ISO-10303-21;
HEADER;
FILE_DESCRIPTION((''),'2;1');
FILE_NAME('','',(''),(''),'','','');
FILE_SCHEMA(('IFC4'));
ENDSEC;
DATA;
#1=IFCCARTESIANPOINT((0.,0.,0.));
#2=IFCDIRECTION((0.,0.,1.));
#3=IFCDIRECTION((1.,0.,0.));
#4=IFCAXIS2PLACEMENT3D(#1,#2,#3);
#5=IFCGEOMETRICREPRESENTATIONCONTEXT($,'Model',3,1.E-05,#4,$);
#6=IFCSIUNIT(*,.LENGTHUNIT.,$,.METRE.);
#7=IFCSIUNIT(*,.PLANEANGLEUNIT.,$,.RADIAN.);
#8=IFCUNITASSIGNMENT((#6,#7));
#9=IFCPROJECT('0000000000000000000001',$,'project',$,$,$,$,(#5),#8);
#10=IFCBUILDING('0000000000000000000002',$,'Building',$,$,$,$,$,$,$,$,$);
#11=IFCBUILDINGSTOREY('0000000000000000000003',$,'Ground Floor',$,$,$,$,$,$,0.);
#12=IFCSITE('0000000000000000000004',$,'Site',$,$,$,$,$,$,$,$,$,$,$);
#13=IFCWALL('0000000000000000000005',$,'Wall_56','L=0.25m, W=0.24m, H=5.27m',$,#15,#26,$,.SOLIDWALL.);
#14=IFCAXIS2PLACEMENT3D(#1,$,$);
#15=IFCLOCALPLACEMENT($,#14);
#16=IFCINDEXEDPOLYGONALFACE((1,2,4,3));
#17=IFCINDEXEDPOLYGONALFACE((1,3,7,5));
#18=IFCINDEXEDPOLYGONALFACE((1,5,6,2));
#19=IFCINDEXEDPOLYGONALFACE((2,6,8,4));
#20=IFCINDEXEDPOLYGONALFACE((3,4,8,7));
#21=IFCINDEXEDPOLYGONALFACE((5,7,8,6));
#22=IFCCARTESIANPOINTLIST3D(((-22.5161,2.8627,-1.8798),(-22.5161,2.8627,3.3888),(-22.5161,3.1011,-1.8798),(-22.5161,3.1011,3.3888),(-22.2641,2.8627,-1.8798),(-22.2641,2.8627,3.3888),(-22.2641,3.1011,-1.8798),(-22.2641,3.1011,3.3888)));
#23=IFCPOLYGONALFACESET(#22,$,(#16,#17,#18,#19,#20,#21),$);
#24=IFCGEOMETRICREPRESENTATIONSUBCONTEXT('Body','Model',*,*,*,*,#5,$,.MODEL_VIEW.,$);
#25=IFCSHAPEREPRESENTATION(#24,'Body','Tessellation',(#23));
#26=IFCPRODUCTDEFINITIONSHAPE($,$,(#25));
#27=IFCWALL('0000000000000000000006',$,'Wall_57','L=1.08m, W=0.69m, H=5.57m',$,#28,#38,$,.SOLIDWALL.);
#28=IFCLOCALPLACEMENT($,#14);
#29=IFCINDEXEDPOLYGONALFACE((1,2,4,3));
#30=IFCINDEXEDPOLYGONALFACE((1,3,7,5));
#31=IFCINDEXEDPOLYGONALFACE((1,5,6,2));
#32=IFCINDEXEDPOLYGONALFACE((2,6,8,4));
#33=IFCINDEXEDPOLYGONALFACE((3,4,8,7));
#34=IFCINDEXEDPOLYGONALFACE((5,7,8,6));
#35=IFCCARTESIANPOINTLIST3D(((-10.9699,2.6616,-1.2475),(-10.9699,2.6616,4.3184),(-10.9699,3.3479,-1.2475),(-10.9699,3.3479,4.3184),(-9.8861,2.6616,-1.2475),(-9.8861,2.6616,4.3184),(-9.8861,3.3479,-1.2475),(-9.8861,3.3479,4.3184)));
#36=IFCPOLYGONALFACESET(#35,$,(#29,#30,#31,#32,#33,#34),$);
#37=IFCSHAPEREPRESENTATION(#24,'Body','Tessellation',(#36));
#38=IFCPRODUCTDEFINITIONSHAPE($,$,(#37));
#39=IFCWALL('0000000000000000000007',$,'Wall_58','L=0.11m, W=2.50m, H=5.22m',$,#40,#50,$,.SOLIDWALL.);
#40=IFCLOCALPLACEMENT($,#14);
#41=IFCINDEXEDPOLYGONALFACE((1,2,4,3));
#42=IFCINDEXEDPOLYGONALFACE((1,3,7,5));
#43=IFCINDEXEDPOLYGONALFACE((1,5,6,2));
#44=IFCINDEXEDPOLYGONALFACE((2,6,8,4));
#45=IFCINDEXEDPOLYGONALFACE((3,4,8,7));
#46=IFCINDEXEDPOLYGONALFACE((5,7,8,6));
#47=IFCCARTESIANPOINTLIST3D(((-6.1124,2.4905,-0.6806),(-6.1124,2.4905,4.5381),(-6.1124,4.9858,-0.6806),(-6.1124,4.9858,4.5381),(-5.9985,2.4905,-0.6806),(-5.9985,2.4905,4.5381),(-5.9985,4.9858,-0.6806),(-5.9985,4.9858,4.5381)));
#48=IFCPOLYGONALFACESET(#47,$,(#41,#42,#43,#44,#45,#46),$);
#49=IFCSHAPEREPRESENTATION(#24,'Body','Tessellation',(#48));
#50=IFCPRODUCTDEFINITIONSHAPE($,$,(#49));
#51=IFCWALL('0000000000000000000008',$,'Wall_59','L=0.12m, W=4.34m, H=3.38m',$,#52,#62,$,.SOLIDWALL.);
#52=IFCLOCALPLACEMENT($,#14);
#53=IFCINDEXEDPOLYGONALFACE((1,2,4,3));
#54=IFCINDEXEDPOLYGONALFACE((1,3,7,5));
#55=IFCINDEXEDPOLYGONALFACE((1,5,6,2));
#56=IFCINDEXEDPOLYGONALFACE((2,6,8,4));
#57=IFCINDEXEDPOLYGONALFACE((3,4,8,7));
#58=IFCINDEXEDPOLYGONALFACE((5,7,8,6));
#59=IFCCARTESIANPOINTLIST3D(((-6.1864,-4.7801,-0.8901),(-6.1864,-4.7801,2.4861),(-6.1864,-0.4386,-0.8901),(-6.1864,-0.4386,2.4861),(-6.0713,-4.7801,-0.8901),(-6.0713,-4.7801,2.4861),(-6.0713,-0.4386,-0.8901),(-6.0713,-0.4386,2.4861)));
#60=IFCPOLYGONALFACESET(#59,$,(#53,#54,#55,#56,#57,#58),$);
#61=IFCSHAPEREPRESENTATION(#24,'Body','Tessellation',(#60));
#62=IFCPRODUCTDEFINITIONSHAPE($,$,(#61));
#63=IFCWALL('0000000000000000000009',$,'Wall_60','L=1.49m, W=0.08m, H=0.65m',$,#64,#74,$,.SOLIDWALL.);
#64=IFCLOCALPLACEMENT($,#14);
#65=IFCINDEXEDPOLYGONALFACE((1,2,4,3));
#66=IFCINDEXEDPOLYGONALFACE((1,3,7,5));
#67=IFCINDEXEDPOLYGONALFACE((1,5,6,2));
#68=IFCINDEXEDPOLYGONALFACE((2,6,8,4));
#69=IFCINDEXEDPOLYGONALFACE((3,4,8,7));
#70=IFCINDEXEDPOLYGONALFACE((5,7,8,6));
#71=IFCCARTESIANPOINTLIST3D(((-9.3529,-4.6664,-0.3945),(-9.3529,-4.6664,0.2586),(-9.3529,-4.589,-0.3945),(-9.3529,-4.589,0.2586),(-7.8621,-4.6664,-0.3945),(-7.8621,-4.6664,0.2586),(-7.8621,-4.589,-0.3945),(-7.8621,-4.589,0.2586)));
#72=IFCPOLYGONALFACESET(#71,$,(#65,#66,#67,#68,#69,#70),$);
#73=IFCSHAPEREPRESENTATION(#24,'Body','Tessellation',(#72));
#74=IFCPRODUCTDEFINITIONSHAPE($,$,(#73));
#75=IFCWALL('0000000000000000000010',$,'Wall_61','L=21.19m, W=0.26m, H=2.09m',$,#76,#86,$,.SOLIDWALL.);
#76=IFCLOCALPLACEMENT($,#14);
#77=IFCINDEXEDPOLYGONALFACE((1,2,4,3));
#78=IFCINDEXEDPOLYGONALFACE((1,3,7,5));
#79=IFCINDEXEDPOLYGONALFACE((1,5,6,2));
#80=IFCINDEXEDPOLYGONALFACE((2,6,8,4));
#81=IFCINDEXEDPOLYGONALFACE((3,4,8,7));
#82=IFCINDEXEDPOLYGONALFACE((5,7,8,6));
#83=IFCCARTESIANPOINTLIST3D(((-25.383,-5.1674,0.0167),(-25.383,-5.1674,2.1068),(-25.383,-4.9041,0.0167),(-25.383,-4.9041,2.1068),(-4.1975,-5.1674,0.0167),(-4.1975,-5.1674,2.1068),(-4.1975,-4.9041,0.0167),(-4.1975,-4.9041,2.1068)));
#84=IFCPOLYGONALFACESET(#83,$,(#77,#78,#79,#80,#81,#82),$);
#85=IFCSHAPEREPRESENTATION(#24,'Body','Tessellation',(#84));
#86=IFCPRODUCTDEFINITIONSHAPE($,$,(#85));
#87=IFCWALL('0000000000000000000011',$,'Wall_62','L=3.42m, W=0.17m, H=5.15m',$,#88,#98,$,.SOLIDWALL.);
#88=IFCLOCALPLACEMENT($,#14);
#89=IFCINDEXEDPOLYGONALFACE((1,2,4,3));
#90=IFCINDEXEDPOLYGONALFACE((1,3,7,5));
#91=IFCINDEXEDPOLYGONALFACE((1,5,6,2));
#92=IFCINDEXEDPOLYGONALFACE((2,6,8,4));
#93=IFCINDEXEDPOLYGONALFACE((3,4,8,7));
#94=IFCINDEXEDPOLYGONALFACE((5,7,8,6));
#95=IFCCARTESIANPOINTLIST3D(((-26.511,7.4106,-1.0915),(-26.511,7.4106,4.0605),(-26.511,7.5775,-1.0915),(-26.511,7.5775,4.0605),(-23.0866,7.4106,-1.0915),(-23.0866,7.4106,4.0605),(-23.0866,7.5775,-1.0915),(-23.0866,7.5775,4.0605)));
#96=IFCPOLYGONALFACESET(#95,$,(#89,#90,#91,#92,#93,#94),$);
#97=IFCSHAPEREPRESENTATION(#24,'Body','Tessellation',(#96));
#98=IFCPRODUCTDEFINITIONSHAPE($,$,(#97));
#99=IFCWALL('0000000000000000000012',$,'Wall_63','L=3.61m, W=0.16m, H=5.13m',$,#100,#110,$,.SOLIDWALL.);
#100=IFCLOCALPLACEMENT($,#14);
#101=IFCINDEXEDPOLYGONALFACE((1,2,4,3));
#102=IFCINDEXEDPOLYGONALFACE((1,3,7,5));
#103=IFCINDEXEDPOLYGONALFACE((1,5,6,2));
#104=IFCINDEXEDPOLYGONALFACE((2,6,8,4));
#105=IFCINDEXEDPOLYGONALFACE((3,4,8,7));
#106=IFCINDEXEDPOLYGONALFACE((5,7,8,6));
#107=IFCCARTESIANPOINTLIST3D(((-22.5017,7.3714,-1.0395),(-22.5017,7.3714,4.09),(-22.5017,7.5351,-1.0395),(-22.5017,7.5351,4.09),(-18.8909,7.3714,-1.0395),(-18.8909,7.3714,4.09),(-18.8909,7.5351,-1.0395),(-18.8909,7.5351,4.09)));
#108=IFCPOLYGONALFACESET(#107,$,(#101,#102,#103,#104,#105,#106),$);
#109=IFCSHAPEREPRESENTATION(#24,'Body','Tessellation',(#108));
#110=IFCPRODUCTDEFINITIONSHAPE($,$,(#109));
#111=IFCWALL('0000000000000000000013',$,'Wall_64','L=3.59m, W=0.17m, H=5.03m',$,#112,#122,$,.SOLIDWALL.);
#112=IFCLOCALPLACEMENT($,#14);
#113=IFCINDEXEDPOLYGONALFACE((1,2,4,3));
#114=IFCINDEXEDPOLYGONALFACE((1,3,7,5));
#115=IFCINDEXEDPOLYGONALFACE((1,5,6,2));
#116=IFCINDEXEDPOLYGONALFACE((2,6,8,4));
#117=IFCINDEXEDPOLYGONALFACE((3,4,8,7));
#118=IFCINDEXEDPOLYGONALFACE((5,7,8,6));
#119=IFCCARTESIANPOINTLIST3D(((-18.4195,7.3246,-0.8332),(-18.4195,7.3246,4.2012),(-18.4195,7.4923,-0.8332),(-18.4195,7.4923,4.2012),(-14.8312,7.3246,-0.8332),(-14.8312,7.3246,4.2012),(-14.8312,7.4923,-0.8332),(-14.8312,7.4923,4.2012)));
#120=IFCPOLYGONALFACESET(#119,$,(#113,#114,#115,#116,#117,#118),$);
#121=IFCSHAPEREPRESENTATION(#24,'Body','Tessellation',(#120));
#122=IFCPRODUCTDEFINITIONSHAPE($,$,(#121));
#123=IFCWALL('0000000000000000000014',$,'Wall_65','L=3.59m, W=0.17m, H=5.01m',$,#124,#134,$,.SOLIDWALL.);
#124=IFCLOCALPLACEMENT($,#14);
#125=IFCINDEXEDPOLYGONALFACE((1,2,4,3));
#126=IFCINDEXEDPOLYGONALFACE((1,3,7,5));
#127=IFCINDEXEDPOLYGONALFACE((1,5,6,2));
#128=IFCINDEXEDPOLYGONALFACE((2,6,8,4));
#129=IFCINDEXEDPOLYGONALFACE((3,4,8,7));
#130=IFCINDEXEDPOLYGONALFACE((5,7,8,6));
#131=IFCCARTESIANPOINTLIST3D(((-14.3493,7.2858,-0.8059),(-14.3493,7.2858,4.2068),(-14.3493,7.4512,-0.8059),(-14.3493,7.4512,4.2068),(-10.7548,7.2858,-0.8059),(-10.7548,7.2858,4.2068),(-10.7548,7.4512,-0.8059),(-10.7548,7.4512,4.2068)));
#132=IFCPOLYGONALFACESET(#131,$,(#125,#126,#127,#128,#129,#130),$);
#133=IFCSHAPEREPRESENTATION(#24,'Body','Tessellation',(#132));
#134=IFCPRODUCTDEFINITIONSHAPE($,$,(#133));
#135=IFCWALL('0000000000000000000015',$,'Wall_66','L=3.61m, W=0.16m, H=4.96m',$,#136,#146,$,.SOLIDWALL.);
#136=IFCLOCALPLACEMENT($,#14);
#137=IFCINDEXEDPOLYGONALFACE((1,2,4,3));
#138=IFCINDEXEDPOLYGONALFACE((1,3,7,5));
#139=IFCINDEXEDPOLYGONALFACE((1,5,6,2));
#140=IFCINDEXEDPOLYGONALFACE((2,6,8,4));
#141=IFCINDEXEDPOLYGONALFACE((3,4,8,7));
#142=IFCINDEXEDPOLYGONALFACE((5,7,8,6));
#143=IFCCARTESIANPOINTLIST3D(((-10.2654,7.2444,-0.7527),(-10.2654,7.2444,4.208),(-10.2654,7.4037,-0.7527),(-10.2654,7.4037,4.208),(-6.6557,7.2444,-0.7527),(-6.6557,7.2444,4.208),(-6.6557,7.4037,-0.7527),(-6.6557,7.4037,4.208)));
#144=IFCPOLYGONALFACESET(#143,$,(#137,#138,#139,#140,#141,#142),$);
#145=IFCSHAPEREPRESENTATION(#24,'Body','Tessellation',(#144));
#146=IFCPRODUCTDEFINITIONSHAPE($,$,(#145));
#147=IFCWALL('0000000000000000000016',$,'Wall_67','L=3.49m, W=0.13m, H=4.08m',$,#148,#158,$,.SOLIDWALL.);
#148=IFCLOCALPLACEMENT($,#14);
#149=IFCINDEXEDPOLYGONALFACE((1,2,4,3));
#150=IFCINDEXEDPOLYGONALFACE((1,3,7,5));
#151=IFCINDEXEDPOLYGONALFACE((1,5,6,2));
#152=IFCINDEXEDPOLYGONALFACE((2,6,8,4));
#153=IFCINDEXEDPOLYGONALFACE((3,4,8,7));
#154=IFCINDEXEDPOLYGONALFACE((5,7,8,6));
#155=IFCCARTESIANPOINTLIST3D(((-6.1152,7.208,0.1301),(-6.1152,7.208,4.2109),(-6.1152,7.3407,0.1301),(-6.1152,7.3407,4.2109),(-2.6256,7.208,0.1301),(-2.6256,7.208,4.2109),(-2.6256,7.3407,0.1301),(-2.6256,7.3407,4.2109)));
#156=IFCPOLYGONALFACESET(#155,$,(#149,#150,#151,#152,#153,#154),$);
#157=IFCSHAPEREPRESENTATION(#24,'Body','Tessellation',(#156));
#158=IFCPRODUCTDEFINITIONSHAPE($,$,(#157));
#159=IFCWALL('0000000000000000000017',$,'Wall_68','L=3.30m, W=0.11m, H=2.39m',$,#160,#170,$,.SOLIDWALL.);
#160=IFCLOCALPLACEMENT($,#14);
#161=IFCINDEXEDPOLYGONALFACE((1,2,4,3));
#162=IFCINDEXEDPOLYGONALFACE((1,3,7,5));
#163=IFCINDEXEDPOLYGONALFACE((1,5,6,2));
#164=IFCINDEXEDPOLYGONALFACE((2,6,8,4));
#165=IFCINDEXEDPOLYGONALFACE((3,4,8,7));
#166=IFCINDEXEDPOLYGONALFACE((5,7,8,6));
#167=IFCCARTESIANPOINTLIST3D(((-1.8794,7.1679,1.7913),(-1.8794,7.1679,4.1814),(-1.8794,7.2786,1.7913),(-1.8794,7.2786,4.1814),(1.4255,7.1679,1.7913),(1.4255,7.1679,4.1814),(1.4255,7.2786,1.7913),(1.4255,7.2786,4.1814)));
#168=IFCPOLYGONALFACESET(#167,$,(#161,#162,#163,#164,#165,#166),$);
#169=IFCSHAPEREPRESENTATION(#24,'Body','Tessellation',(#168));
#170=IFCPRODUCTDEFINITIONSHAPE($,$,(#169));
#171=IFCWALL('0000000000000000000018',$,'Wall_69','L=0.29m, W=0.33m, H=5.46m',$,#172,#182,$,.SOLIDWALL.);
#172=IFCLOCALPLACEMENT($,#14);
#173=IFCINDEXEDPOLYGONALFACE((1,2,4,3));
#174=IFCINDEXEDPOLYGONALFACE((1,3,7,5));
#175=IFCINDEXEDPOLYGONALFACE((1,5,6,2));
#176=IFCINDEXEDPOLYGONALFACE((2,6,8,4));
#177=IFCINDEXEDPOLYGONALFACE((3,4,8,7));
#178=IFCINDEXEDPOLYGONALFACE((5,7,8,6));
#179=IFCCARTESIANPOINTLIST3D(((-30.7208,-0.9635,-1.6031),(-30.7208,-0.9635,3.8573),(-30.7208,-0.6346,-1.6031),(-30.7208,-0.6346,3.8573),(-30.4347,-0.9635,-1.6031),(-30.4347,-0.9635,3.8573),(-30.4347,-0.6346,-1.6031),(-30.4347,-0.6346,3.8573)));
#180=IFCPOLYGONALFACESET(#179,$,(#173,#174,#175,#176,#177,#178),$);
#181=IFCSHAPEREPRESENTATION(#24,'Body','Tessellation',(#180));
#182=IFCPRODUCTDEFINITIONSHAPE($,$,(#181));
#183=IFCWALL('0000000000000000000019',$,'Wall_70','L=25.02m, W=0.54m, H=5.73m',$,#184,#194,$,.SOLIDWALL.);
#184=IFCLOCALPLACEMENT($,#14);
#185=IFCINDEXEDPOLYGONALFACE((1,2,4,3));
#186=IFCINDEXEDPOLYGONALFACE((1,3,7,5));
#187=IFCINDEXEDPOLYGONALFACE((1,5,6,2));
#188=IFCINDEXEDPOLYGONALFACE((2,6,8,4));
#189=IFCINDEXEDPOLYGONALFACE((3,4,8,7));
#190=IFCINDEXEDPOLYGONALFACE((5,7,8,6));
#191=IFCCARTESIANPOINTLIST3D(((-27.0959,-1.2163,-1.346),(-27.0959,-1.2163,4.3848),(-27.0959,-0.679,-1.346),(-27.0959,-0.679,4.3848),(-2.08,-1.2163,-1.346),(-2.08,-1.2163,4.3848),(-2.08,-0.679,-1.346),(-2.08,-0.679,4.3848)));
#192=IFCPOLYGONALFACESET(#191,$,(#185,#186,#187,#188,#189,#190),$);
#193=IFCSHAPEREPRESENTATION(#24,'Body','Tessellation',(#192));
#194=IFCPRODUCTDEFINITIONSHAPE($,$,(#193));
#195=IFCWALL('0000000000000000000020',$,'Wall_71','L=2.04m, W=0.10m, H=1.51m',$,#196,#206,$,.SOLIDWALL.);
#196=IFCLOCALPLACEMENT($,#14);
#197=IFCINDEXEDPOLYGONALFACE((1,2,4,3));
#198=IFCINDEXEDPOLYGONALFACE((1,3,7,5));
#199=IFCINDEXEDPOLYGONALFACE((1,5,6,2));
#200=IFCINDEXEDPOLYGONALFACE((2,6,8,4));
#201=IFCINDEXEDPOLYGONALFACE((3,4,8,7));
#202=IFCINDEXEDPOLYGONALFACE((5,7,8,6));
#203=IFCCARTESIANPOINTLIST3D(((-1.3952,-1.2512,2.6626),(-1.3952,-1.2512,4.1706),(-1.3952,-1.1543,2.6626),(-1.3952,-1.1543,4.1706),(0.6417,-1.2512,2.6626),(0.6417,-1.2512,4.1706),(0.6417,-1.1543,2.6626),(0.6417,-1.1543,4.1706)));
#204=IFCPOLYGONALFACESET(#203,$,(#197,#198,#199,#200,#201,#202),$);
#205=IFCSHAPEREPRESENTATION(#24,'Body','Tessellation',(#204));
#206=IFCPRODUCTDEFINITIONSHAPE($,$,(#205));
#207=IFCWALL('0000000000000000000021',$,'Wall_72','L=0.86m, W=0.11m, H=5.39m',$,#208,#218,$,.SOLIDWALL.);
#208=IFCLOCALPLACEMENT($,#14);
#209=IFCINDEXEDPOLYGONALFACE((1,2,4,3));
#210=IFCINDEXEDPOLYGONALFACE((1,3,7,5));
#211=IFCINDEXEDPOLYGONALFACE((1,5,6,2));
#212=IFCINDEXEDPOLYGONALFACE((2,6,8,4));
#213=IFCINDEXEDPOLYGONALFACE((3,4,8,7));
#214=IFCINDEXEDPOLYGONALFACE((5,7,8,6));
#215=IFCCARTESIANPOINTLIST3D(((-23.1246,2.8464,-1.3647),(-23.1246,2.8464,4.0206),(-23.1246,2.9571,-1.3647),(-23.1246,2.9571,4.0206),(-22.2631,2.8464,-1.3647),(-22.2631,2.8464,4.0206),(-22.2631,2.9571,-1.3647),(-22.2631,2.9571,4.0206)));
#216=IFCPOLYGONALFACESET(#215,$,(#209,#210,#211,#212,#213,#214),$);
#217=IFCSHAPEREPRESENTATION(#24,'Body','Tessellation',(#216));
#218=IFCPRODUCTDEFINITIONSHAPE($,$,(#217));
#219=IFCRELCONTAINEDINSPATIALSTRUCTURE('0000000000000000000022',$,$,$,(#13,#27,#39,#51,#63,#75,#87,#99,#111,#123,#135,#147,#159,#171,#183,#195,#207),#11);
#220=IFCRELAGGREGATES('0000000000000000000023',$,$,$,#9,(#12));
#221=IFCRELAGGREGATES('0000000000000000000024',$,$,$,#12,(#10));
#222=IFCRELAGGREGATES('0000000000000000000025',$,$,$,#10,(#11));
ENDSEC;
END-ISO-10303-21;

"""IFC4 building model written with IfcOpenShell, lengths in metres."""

from ifc_helpers import new_model, si_unit, frame, origin_with_axes, origin_2d, context, subcontext, project, spatial, rectangle, extrude, element, save


model = new_model("IFC4")

# Units and contexts
model_context = context("Model", 3, precision=1e-05, world=origin_with_axes())
body_context = subcontext(model_context, "Body", "Model", "MODEL_VIEW")
ifc_project = project(units=[si_unit("LENGTHUNIT", "METRE"), si_unit("PLANEANGLEUNIT", "RADIAN")], contexts=[model_context])

# Site, building, storey
site = spatial("IfcSite", under=ifc_project, Name="Site")
building = spatial("IfcBuilding", under=site, Name="Building")
storey = spatial("IfcBuildingStorey", under=building, Name="Ground Floor", Elevation=0.0)

# Walls
element("IfcWall", 1, inside=storey, Name="Wall_56", Description="L=0.25m, W=0.24m, H=5.27m", PredefinedType="SOLIDWALL", context=body_context, shape_type="SweptSolid", body=[
    extrude(rectangle(XDim=0.252, YDim=0.2384, at=origin_2d()), frame((-22.3901, 2.9819, -1.8798), z_axis=(0.0, 0.0, 1.0), x_axis=(1.0, 0.0, 0.0)), (0.0, 0.0, 1.0), 5.2687),
])
element("IfcWall", 2, inside=storey, Name="Wall_57", Description="L=1.08m, W=0.69m, H=5.57m", PredefinedType="SOLIDWALL", context=body_context, shape_type="SweptSolid", body=[
    extrude(rectangle(XDim=1.0838, YDim=0.6863, at=origin_2d()), frame((-10.428, 3.0048, -1.2475), z_axis=(0.0, 0.0, 1.0), x_axis=(1.0, 0.0, 0.0)), (0.0, 0.0, 1.0), 5.5659),
])
element("IfcWall", 3, inside=storey, Name="Wall_58", Description="L=0.11m, W=2.50m, H=5.22m", PredefinedType="SOLIDWALL", context=body_context, shape_type="SweptSolid", body=[
    extrude(rectangle(XDim=0.114, YDim=2.4953, at=origin_2d()), frame((-6.0555, 3.7382, -0.6806), z_axis=(0.0, 0.0, 1.0), x_axis=(1.0, 0.0, 0.0)), (0.0, 0.0, 1.0), 5.2186),
])
element("IfcWall", 4, inside=storey, Name="Wall_59", Description="L=0.12m, W=4.34m, H=3.38m", PredefinedType="SOLIDWALL", context=body_context, shape_type="SweptSolid", body=[
    extrude(rectangle(XDim=0.1151, YDim=4.3415, at=origin_2d()), frame((-6.1289, -2.6094, -0.8901), z_axis=(0.0, 0.0, 1.0), x_axis=(1.0, 0.0, 0.0)), (0.0, 0.0, 1.0), 3.3762),
])
element("IfcWall", 5, inside=storey, Name="Wall_60", Description="L=1.49m, W=0.08m, H=0.65m", PredefinedType="SOLIDWALL", context=body_context, shape_type="SweptSolid", body=[
    extrude(rectangle(XDim=1.4908, YDim=0.0774, at=origin_2d()), frame((-8.6075, -4.6277, -0.3945), z_axis=(0.0, 0.0, 1.0), x_axis=(1.0, 0.0, 0.0)), (0.0, 0.0, 1.0), 0.6531),
])
element("IfcWall", 6, inside=storey, Name="Wall_61", Description="L=21.19m, W=0.26m, H=2.09m", PredefinedType="SOLIDWALL", context=body_context, shape_type="SweptSolid", body=[
    extrude(rectangle(XDim=21.1854, YDim=0.2632, at=origin_2d()), frame((-14.7902, -5.0357, 0.0167), z_axis=(0.0, 0.0, 1.0), x_axis=(1.0, 0.0, 0.0)), (0.0, 0.0, 1.0), 2.0901),
])
element("IfcWall", 7, inside=storey, Name="Wall_62", Description="L=3.42m, W=0.17m, H=5.15m", PredefinedType="SOLIDWALL", context=body_context, shape_type="SweptSolid", body=[
    extrude(rectangle(XDim=3.4244, YDim=0.1669, at=origin_2d()), frame((-24.7988, 7.494, -1.0915), z_axis=(0.0, 0.0, 1.0), x_axis=(1.0, 0.0, 0.0)), (0.0, 0.0, 1.0), 5.152),
])
element("IfcWall", 8, inside=storey, Name="Wall_63", Description="L=3.61m, W=0.16m, H=5.13m", PredefinedType="SOLIDWALL", context=body_context, shape_type="SweptSolid", body=[
    extrude(rectangle(XDim=3.6108, YDim=0.1637, at=origin_2d()), frame((-20.6963, 7.4533, -1.0395), z_axis=(0.0, 0.0, 1.0), x_axis=(1.0, 0.0, 0.0)), (0.0, 0.0, 1.0), 5.1295),
])
element("IfcWall", 9, inside=storey, Name="Wall_64", Description="L=3.59m, W=0.17m, H=5.03m", PredefinedType="SOLIDWALL", context=body_context, shape_type="SweptSolid", body=[
    extrude(rectangle(XDim=3.5883, YDim=0.1677, at=origin_2d()), frame((-16.6253, 7.4085, -0.8332), z_axis=(0.0, 0.0, 1.0), x_axis=(1.0, 0.0, 0.0)), (0.0, 0.0, 1.0), 5.0343),
])
element("IfcWall", 10, inside=storey, Name="Wall_65", Description="L=3.59m, W=0.17m, H=5.01m", PredefinedType="SOLIDWALL", context=body_context, shape_type="SweptSolid", body=[
    extrude(rectangle(XDim=3.5945, YDim=0.1655, at=origin_2d()), frame((-12.552, 7.3685, -0.8059), z_axis=(0.0, 0.0, 1.0), x_axis=(1.0, 0.0, 0.0)), (0.0, 0.0, 1.0), 5.0127),
])
element("IfcWall", 11, inside=storey, Name="Wall_66", Description="L=3.61m, W=0.16m, H=4.96m", PredefinedType="SOLIDWALL", context=body_context, shape_type="SweptSolid", body=[
    extrude(rectangle(XDim=3.6097, YDim=0.1593, at=origin_2d()), frame((-8.4605, 7.324, -0.7527), z_axis=(0.0, 0.0, 1.0), x_axis=(1.0, 0.0, 0.0)), (0.0, 0.0, 1.0), 4.9606),
])
element("IfcWall", 12, inside=storey, Name="Wall_67", Description="L=3.49m, W=0.13m, H=4.08m", PredefinedType="SOLIDWALL", context=body_context, shape_type="SweptSolid", body=[
    extrude(rectangle(XDim=3.4897, YDim=0.1327, at=origin_2d()), frame((-4.3704, 7.2743, 0.1301), z_axis=(0.0, 0.0, 1.0), x_axis=(1.0, 0.0, 0.0)), (0.0, 0.0, 1.0), 4.0809),
])
element("IfcWall", 13, inside=storey, Name="Wall_68", Description="L=3.30m, W=0.11m, H=2.39m", PredefinedType="SOLIDWALL", context=body_context, shape_type="SweptSolid", body=[
    extrude(rectangle(XDim=3.305, YDim=0.1107, at=origin_2d()), frame((-0.227, 7.2232, 1.7913), z_axis=(0.0, 0.0, 1.0), x_axis=(1.0, 0.0, 0.0)), (0.0, 0.0, 1.0), 2.3901),
])
element("IfcWall", 14, inside=storey, Name="Wall_69", Description="L=0.29m, W=0.33m, H=5.46m", PredefinedType="SOLIDWALL", context=body_context, shape_type="SweptSolid", body=[
    extrude(rectangle(XDim=0.2861, YDim=0.3289, at=origin_2d()), frame((-30.5778, -0.799, -1.6031), z_axis=(0.0, 0.0, 1.0), x_axis=(1.0, 0.0, 0.0)), (0.0, 0.0, 1.0), 5.4605),
])
element("IfcWall", 15, inside=storey, Name="Wall_70", Description="L=25.02m, W=0.54m, H=5.73m", PredefinedType="SOLIDWALL", context=body_context, shape_type="SweptSolid", body=[
    extrude(rectangle(XDim=25.0159, YDim=0.5374, at=origin_2d()), frame((-14.5879, -0.9476, -1.346), z_axis=(0.0, 0.0, 1.0), x_axis=(1.0, 0.0, 0.0)), (0.0, 0.0, 1.0), 5.7308),
])
element("IfcWall", 16, inside=storey, Name="Wall_71", Description="L=2.04m, W=0.10m, H=1.51m", PredefinedType="SOLIDWALL", context=body_context, shape_type="SweptSolid", body=[
    extrude(rectangle(XDim=2.037, YDim=0.097, at=origin_2d()), frame((-0.3768, -1.2027, 2.6626), z_axis=(0.0, 0.0, 1.0), x_axis=(1.0, 0.0, 0.0)), (0.0, 0.0, 1.0), 1.5081),
])
element("IfcWall", 17, inside=storey, Name="Wall_72", Description="L=0.86m, W=0.11m, H=5.39m", PredefinedType="SOLIDWALL", context=body_context, shape_type="SweptSolid", body=[
    extrude(rectangle(XDim=0.8615, YDim=0.1107, at=origin_2d()), frame((-22.6939, 2.9017, -1.3647), z_axis=(0.0, 0.0, 1.0), x_axis=(1.0, 0.0, 0.0)), (0.0, 0.0, 1.0), 5.3853),
])

save(model, "model.ifc")
